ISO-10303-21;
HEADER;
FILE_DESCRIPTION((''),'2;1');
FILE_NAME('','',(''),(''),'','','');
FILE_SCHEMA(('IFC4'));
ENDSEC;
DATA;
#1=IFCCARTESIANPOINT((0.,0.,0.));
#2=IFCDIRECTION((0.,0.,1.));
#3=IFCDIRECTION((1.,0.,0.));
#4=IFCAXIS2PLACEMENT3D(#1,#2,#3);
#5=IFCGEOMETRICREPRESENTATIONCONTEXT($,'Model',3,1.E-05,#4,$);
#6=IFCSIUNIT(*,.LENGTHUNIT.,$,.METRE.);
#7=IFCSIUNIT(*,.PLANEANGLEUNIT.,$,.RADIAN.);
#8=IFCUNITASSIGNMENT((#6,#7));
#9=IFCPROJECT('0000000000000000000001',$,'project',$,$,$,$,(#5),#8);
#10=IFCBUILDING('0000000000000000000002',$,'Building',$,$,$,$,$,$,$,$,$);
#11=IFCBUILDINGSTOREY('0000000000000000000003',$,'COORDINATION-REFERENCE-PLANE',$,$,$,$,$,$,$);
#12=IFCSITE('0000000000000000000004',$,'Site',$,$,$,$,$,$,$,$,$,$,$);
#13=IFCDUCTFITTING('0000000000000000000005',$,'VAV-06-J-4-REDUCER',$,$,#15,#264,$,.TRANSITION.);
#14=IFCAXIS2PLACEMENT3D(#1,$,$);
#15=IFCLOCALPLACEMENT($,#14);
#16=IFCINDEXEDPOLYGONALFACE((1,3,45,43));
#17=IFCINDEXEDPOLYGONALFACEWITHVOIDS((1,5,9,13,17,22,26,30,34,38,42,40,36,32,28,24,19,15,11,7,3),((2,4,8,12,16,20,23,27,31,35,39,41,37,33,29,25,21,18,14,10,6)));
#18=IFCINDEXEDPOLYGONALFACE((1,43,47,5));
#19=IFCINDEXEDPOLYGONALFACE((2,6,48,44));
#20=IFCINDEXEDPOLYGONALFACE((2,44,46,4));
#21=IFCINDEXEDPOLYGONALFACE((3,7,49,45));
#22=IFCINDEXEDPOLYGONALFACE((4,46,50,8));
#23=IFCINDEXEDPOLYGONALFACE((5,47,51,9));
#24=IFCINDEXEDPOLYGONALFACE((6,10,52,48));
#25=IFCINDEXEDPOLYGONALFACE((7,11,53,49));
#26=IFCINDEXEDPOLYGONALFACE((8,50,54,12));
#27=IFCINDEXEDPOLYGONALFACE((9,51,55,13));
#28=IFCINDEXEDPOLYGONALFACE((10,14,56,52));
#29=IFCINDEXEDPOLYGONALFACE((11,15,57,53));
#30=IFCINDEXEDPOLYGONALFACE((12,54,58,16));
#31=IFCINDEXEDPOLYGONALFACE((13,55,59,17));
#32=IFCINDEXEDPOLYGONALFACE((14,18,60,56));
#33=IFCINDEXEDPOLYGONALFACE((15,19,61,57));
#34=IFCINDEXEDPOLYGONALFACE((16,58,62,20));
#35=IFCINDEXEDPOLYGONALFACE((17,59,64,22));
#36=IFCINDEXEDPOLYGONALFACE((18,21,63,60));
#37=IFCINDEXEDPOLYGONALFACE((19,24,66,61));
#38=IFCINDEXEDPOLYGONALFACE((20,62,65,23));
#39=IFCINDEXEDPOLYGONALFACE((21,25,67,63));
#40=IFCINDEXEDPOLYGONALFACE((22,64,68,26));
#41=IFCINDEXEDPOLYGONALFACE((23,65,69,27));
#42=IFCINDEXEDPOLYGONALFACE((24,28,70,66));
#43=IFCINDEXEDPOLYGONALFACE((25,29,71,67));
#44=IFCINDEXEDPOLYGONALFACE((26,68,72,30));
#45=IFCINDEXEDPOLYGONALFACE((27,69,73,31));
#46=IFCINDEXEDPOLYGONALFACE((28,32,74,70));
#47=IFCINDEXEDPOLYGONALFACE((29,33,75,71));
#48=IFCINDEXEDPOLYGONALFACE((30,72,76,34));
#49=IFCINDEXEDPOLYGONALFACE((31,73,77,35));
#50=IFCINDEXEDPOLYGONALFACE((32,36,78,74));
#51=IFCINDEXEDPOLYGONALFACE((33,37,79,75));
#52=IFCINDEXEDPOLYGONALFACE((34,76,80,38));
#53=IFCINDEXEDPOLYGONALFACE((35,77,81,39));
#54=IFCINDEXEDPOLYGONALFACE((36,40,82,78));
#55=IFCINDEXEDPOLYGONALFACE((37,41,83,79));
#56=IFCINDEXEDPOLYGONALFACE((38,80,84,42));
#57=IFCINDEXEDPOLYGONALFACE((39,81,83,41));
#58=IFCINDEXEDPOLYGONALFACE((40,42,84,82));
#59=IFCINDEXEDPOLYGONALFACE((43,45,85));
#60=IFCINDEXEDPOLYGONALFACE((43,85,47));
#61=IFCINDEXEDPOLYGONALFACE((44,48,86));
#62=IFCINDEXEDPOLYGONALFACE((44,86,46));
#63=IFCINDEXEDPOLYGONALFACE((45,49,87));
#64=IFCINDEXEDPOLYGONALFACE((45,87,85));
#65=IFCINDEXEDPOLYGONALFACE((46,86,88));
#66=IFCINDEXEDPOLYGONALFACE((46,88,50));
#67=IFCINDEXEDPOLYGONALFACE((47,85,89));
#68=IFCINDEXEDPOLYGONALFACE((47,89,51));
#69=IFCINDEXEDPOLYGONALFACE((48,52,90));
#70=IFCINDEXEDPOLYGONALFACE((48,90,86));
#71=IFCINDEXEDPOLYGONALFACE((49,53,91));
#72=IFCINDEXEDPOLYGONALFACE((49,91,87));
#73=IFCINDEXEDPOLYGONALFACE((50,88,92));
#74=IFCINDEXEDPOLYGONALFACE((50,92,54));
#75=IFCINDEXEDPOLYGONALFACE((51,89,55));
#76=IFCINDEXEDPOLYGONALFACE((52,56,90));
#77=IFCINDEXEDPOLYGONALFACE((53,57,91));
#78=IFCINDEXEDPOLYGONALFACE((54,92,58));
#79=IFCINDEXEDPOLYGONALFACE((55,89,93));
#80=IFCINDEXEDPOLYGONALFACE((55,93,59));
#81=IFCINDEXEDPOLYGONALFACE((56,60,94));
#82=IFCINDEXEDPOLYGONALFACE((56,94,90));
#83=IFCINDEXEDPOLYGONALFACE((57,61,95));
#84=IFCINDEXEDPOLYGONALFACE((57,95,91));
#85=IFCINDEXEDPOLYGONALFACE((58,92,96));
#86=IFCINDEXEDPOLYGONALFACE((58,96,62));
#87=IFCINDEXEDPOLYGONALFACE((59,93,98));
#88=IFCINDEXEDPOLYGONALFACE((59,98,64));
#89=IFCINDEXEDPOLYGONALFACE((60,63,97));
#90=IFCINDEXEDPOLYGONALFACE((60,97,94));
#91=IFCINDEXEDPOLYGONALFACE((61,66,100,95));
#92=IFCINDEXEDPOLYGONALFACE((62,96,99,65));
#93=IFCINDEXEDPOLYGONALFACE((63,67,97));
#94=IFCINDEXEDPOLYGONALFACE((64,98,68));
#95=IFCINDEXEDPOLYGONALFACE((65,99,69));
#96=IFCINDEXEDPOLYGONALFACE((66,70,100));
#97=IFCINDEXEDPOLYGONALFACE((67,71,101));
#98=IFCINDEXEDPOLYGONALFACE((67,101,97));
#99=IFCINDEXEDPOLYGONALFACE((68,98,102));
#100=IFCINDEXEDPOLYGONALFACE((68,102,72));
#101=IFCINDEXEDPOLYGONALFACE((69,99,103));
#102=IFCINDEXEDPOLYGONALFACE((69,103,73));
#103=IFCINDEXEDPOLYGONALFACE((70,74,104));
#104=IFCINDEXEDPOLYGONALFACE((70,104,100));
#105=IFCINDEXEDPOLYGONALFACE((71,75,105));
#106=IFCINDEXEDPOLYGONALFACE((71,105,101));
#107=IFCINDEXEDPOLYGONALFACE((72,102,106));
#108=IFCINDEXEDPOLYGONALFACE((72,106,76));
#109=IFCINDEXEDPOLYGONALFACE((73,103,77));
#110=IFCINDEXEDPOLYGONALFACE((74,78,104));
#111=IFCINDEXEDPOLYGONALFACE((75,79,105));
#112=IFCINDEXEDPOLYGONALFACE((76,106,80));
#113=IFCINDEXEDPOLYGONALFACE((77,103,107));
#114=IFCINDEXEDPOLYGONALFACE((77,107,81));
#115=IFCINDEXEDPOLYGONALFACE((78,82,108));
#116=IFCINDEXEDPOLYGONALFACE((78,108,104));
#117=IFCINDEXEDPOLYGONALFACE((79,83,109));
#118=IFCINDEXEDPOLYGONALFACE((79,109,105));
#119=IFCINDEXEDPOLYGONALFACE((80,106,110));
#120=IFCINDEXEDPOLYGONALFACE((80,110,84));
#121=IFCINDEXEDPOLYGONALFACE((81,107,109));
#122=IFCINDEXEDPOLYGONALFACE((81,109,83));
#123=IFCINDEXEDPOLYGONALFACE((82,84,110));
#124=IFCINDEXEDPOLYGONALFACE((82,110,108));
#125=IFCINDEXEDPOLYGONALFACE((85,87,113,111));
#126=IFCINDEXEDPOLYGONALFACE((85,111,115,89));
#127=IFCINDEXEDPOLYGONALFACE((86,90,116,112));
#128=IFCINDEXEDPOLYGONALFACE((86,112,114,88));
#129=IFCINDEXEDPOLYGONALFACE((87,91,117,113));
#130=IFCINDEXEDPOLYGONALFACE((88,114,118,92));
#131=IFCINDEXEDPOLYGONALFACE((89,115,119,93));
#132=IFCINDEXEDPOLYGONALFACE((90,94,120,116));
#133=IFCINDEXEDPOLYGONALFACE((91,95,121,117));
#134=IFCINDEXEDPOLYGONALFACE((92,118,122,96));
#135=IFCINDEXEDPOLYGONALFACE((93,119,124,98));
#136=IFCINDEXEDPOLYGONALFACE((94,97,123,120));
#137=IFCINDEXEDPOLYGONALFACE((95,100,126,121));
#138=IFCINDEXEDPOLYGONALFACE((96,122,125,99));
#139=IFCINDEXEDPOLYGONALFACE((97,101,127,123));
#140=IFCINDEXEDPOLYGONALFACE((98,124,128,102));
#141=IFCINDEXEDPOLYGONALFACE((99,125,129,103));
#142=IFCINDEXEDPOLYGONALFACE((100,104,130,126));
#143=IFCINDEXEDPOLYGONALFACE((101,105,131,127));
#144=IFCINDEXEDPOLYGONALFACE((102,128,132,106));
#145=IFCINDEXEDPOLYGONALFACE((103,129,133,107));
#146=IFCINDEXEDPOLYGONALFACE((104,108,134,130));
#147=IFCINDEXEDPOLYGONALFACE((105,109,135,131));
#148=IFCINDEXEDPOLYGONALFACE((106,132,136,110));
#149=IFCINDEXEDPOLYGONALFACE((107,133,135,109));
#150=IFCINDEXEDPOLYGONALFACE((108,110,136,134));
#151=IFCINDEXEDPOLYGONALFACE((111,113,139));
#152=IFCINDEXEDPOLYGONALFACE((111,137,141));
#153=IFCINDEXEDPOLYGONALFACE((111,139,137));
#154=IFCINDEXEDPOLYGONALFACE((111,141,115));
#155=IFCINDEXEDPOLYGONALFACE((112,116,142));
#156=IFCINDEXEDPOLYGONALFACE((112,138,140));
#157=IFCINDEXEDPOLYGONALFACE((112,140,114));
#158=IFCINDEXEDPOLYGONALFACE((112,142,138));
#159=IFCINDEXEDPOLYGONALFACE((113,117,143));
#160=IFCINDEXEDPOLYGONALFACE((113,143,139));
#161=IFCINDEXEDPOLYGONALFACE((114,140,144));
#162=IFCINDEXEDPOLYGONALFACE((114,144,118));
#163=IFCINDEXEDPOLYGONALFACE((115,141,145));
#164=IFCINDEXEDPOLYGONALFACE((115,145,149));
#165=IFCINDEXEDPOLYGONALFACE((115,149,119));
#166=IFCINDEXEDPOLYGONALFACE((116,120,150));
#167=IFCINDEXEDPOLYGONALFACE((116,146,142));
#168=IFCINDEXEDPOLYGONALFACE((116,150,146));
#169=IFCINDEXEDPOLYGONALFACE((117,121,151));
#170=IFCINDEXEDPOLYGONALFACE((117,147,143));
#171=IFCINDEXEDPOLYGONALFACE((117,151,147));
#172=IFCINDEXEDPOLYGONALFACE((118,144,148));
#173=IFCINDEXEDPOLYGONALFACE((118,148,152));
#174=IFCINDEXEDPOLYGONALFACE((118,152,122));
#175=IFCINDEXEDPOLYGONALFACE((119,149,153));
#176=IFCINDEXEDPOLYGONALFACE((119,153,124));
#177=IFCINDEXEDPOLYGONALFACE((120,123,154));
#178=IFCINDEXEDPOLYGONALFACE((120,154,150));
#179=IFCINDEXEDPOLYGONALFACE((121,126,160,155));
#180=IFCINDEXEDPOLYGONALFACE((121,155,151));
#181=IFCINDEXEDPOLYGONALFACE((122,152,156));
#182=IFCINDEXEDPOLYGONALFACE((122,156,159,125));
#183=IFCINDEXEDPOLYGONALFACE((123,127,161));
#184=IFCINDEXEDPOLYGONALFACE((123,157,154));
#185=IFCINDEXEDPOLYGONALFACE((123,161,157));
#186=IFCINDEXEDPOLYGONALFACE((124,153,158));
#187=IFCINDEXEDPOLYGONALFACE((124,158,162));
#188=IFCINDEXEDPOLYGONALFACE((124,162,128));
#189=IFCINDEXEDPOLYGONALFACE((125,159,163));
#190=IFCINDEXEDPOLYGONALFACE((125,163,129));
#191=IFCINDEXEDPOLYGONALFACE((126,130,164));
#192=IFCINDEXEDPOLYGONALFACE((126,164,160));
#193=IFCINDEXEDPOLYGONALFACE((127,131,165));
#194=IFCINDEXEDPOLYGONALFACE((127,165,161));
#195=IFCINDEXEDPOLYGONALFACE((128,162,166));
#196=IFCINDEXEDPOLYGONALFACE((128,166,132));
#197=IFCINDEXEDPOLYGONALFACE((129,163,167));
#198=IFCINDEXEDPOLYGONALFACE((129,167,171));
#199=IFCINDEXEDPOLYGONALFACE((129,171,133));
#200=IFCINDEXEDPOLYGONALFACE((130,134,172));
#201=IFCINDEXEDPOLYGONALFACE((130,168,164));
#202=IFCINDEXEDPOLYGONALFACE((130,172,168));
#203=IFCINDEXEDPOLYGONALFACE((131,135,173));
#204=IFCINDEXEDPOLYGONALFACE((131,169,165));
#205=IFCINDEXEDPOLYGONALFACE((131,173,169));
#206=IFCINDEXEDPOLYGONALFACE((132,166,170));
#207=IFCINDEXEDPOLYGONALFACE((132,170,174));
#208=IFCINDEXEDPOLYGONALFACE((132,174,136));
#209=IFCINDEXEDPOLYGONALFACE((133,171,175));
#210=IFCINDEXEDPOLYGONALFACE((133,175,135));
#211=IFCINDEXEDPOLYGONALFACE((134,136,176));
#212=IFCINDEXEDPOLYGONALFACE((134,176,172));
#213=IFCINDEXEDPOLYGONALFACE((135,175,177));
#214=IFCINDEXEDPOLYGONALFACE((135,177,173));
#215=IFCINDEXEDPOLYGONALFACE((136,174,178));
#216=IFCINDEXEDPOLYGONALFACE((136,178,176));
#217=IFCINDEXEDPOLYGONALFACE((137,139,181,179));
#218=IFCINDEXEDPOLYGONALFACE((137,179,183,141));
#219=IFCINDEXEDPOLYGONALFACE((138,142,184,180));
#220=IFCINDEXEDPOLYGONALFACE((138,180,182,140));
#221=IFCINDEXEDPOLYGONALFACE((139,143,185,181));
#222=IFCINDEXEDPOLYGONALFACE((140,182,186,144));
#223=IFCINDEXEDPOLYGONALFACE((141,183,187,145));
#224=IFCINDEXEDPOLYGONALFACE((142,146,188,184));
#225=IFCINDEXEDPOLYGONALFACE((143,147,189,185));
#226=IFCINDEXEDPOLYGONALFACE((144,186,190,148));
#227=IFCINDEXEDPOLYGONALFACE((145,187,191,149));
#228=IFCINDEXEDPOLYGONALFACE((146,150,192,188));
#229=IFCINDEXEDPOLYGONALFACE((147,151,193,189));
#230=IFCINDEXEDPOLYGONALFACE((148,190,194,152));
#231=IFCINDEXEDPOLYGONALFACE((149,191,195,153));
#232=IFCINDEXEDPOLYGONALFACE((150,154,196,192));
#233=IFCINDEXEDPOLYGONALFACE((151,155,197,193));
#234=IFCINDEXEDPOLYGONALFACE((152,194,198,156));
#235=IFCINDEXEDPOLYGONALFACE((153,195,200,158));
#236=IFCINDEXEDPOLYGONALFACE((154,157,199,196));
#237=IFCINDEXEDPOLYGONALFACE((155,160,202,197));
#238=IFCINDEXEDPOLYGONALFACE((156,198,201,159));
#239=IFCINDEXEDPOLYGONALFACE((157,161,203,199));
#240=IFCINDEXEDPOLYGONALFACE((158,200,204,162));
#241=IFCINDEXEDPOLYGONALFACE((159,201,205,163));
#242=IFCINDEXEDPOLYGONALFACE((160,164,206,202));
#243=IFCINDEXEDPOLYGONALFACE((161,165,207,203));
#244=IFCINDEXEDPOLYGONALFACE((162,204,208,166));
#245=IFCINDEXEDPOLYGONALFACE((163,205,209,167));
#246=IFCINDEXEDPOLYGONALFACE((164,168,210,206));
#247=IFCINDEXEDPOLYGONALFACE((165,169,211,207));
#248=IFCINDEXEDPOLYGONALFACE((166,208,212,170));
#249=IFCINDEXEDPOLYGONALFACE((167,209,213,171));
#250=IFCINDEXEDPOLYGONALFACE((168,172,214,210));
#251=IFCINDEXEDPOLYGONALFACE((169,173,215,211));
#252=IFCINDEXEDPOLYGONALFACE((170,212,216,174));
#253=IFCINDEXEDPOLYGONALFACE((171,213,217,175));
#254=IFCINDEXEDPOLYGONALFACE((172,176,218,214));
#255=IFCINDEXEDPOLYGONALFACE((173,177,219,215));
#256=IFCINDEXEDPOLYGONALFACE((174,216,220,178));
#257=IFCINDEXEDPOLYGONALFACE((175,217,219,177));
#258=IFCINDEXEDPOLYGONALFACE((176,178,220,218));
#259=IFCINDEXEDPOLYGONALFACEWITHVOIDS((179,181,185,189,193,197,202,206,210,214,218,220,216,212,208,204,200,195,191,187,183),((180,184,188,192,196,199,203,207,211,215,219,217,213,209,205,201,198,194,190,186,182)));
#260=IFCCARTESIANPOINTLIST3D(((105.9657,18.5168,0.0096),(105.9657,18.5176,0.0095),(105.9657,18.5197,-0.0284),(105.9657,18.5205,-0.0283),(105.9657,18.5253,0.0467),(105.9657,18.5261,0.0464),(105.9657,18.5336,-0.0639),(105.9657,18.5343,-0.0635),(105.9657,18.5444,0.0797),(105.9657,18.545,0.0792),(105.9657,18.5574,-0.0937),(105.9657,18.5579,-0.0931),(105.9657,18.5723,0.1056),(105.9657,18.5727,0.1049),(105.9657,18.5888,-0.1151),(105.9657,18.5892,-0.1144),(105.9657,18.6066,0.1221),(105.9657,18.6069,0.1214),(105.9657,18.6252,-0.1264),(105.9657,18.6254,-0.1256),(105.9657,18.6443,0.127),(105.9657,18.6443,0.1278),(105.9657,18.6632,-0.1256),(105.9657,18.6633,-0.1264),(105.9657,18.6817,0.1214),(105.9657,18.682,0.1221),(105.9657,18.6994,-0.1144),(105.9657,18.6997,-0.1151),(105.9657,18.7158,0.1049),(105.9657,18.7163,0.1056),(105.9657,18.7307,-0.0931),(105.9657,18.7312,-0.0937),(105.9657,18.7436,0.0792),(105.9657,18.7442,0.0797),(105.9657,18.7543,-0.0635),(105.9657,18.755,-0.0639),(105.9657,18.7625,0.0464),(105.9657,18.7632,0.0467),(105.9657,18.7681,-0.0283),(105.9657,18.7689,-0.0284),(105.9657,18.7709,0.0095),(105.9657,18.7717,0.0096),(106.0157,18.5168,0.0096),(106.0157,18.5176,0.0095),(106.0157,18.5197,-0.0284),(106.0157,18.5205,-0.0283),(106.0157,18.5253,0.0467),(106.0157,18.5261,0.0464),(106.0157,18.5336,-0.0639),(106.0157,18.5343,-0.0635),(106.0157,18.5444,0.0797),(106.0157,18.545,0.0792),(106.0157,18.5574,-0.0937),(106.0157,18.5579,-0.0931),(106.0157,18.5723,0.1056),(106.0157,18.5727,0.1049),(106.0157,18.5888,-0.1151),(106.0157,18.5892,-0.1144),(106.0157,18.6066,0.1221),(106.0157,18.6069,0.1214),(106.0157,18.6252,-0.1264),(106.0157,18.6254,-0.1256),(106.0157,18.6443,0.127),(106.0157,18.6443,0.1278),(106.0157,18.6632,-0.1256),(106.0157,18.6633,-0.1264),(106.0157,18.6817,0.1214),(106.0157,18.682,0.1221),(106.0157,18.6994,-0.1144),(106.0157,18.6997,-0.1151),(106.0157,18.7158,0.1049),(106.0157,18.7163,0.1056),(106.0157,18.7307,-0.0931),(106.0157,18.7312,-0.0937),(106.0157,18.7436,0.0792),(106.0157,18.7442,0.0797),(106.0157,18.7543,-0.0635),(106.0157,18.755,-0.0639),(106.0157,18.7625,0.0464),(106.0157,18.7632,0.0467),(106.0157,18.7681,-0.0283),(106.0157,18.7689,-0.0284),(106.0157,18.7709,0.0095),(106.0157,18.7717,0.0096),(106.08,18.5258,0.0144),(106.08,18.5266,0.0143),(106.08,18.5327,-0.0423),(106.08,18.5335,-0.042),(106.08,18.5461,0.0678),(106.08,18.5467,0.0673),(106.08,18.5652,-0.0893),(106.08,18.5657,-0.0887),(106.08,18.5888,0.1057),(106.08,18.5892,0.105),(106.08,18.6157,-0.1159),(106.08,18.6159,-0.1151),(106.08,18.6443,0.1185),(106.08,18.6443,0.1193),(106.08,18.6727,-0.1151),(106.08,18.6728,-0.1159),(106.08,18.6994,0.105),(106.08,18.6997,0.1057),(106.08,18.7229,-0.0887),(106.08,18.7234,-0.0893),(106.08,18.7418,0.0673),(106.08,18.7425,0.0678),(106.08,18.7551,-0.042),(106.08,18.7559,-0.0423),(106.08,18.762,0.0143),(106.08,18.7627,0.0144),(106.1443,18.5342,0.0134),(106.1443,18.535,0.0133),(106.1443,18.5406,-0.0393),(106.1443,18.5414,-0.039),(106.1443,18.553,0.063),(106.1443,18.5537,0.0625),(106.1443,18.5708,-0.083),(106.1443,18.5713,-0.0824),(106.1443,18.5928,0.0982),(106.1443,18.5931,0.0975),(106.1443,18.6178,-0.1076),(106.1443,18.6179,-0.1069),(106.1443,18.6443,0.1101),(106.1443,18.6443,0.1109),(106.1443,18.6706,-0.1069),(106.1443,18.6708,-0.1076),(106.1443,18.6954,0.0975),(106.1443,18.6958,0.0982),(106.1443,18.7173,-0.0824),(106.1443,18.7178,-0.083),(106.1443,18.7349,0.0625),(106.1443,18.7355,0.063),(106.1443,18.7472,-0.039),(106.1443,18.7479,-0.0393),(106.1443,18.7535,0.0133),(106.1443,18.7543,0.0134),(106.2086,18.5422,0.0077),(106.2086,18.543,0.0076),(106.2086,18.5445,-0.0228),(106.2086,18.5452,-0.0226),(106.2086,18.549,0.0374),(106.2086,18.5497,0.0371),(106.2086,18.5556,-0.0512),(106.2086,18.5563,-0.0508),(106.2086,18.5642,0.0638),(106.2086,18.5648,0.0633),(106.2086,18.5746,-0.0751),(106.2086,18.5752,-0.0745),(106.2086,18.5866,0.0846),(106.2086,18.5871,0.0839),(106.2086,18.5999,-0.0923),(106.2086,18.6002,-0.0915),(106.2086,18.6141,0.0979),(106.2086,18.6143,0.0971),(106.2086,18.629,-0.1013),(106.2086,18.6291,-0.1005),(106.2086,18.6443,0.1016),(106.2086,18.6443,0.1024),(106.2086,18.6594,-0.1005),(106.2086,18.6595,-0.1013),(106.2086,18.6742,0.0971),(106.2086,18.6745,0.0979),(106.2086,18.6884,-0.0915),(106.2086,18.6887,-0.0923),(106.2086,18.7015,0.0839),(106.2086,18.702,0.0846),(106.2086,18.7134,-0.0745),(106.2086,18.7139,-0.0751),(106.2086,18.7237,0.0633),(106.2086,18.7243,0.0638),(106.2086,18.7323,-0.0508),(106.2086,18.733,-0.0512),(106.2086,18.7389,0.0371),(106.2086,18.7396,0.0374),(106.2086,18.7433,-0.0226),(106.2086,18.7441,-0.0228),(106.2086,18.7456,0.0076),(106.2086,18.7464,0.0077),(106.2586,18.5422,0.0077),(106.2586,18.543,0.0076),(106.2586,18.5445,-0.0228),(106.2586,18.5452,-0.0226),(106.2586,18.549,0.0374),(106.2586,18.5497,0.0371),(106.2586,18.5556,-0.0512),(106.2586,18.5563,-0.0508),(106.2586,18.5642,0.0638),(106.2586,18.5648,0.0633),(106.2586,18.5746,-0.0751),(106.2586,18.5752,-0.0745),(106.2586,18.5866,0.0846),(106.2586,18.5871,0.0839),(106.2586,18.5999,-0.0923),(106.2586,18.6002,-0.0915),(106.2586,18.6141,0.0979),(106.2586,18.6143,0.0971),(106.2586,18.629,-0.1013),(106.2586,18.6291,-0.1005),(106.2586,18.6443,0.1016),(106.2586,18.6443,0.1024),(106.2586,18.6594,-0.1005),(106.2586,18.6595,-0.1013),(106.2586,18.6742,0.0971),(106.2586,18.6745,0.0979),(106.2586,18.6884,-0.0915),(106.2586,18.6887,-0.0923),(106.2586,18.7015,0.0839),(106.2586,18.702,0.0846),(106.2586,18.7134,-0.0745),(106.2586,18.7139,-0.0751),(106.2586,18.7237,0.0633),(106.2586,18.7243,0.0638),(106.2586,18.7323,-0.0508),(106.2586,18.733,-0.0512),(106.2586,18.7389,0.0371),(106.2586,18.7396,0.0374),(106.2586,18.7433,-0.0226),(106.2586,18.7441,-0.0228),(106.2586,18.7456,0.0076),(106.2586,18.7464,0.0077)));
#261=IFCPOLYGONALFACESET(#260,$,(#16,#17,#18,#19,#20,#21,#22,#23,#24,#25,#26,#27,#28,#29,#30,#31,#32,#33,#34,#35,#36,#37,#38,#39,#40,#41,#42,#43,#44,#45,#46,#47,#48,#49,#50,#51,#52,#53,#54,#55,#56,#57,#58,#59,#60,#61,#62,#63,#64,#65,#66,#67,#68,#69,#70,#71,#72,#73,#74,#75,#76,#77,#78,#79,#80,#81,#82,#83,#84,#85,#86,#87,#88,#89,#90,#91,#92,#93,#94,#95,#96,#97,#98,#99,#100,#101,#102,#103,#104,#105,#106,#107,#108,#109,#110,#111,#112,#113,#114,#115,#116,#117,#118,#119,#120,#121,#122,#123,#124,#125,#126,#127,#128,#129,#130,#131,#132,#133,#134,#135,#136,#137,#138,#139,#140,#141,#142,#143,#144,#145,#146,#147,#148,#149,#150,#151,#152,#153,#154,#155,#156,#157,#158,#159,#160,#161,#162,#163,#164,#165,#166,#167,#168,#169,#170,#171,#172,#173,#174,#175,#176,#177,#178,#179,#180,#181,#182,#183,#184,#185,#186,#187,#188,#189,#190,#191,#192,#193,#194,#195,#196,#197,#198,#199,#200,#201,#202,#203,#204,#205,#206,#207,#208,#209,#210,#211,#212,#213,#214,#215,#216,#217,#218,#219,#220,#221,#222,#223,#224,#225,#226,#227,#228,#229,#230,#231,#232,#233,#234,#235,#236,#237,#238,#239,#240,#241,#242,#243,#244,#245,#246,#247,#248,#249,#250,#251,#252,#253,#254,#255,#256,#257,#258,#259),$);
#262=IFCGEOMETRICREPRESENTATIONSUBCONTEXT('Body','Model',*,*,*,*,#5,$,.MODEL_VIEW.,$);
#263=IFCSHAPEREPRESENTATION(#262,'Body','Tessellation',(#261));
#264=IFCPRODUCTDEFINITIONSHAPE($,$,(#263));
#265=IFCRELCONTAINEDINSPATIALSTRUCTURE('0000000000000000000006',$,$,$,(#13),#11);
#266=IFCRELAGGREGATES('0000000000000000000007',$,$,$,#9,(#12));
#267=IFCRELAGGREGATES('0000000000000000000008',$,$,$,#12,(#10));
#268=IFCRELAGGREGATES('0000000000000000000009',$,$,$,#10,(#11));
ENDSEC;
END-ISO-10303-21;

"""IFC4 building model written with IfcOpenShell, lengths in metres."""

from ifc_helpers import new_model, entity, si_unit, frame, origin_with_axes, place, context, subcontext, project, spatial, element, save


model = new_model("IFC4")

# Units and contexts
model_context = context("Model", 3, precision=1e-05, world=origin_with_axes())
body_context_1 = subcontext(model_context, "Body", "Model", "MODEL_VIEW")
ifc_project = project(units=[si_unit("LENGTHUNIT", "METRE"), si_unit("PLANEANGLEUNIT", "RADIAN")], contexts=[model_context])

# Site, building, storey
site = spatial("IfcSite", under=ifc_project, Name="Site")
building = spatial("IfcBuilding", under=site, Name="Building")
storey = spatial("IfcBuildingStorey", under=building, Name="COORDINATION-REFERENCE-PLANE")

# Duct fitting
for number, where, z_axis, x_axis, name in (
    (1, (105.9657, 18.6443, 0.0), (0.0, 1.0, 0.0), (0.0, 0.0, 1.0), "VAV-06-J-4-REDUCER"),
):
    element("IfcDuctFitting", number, at=place(None, frame(where, z_axis=z_axis, x_axis=x_axis)), inside=storey, Name=name, PredefinedType="TRANSITION", context=body_context_1, shape_type="SweptSolid", body=[
        entity("IfcRevolvedAreaSolid", entity("IfcArbitraryClosedProfileDef", "AREA", None, entity("IfcPolyline", [entity("IfcCartesianPoint", [0.1278, 0.0]), entity("IfcCartesianPoint", [0.1278, 0.05]), entity("IfcCartesianPoint", [0.1024, 0.2429]), entity("IfcCartesianPoint", [0.1024, 0.2929]), entity("IfcCartesianPoint", [0.1016, 0.2929]), entity("IfcCartesianPoint", [0.1016, 0.2429]), entity("IfcCartesianPoint", [0.127, 0.05]), entity("IfcCartesianPoint", [0.127, 0.0]), entity("IfcCartesianPoint", [0.1278, 0.0])])), entity("IfcAxis2Placement3D", entity("IfcCartesianPoint", [0.0, 0.0, 0.0])), entity("IfcAxis1Placement", entity("IfcCartesianPoint", [0.0, 0.0, 0.0]), entity("IfcDirection", [0.0, 1.0, 0.0])), 6.283185),
    ])

save(model, "model.ifc")
